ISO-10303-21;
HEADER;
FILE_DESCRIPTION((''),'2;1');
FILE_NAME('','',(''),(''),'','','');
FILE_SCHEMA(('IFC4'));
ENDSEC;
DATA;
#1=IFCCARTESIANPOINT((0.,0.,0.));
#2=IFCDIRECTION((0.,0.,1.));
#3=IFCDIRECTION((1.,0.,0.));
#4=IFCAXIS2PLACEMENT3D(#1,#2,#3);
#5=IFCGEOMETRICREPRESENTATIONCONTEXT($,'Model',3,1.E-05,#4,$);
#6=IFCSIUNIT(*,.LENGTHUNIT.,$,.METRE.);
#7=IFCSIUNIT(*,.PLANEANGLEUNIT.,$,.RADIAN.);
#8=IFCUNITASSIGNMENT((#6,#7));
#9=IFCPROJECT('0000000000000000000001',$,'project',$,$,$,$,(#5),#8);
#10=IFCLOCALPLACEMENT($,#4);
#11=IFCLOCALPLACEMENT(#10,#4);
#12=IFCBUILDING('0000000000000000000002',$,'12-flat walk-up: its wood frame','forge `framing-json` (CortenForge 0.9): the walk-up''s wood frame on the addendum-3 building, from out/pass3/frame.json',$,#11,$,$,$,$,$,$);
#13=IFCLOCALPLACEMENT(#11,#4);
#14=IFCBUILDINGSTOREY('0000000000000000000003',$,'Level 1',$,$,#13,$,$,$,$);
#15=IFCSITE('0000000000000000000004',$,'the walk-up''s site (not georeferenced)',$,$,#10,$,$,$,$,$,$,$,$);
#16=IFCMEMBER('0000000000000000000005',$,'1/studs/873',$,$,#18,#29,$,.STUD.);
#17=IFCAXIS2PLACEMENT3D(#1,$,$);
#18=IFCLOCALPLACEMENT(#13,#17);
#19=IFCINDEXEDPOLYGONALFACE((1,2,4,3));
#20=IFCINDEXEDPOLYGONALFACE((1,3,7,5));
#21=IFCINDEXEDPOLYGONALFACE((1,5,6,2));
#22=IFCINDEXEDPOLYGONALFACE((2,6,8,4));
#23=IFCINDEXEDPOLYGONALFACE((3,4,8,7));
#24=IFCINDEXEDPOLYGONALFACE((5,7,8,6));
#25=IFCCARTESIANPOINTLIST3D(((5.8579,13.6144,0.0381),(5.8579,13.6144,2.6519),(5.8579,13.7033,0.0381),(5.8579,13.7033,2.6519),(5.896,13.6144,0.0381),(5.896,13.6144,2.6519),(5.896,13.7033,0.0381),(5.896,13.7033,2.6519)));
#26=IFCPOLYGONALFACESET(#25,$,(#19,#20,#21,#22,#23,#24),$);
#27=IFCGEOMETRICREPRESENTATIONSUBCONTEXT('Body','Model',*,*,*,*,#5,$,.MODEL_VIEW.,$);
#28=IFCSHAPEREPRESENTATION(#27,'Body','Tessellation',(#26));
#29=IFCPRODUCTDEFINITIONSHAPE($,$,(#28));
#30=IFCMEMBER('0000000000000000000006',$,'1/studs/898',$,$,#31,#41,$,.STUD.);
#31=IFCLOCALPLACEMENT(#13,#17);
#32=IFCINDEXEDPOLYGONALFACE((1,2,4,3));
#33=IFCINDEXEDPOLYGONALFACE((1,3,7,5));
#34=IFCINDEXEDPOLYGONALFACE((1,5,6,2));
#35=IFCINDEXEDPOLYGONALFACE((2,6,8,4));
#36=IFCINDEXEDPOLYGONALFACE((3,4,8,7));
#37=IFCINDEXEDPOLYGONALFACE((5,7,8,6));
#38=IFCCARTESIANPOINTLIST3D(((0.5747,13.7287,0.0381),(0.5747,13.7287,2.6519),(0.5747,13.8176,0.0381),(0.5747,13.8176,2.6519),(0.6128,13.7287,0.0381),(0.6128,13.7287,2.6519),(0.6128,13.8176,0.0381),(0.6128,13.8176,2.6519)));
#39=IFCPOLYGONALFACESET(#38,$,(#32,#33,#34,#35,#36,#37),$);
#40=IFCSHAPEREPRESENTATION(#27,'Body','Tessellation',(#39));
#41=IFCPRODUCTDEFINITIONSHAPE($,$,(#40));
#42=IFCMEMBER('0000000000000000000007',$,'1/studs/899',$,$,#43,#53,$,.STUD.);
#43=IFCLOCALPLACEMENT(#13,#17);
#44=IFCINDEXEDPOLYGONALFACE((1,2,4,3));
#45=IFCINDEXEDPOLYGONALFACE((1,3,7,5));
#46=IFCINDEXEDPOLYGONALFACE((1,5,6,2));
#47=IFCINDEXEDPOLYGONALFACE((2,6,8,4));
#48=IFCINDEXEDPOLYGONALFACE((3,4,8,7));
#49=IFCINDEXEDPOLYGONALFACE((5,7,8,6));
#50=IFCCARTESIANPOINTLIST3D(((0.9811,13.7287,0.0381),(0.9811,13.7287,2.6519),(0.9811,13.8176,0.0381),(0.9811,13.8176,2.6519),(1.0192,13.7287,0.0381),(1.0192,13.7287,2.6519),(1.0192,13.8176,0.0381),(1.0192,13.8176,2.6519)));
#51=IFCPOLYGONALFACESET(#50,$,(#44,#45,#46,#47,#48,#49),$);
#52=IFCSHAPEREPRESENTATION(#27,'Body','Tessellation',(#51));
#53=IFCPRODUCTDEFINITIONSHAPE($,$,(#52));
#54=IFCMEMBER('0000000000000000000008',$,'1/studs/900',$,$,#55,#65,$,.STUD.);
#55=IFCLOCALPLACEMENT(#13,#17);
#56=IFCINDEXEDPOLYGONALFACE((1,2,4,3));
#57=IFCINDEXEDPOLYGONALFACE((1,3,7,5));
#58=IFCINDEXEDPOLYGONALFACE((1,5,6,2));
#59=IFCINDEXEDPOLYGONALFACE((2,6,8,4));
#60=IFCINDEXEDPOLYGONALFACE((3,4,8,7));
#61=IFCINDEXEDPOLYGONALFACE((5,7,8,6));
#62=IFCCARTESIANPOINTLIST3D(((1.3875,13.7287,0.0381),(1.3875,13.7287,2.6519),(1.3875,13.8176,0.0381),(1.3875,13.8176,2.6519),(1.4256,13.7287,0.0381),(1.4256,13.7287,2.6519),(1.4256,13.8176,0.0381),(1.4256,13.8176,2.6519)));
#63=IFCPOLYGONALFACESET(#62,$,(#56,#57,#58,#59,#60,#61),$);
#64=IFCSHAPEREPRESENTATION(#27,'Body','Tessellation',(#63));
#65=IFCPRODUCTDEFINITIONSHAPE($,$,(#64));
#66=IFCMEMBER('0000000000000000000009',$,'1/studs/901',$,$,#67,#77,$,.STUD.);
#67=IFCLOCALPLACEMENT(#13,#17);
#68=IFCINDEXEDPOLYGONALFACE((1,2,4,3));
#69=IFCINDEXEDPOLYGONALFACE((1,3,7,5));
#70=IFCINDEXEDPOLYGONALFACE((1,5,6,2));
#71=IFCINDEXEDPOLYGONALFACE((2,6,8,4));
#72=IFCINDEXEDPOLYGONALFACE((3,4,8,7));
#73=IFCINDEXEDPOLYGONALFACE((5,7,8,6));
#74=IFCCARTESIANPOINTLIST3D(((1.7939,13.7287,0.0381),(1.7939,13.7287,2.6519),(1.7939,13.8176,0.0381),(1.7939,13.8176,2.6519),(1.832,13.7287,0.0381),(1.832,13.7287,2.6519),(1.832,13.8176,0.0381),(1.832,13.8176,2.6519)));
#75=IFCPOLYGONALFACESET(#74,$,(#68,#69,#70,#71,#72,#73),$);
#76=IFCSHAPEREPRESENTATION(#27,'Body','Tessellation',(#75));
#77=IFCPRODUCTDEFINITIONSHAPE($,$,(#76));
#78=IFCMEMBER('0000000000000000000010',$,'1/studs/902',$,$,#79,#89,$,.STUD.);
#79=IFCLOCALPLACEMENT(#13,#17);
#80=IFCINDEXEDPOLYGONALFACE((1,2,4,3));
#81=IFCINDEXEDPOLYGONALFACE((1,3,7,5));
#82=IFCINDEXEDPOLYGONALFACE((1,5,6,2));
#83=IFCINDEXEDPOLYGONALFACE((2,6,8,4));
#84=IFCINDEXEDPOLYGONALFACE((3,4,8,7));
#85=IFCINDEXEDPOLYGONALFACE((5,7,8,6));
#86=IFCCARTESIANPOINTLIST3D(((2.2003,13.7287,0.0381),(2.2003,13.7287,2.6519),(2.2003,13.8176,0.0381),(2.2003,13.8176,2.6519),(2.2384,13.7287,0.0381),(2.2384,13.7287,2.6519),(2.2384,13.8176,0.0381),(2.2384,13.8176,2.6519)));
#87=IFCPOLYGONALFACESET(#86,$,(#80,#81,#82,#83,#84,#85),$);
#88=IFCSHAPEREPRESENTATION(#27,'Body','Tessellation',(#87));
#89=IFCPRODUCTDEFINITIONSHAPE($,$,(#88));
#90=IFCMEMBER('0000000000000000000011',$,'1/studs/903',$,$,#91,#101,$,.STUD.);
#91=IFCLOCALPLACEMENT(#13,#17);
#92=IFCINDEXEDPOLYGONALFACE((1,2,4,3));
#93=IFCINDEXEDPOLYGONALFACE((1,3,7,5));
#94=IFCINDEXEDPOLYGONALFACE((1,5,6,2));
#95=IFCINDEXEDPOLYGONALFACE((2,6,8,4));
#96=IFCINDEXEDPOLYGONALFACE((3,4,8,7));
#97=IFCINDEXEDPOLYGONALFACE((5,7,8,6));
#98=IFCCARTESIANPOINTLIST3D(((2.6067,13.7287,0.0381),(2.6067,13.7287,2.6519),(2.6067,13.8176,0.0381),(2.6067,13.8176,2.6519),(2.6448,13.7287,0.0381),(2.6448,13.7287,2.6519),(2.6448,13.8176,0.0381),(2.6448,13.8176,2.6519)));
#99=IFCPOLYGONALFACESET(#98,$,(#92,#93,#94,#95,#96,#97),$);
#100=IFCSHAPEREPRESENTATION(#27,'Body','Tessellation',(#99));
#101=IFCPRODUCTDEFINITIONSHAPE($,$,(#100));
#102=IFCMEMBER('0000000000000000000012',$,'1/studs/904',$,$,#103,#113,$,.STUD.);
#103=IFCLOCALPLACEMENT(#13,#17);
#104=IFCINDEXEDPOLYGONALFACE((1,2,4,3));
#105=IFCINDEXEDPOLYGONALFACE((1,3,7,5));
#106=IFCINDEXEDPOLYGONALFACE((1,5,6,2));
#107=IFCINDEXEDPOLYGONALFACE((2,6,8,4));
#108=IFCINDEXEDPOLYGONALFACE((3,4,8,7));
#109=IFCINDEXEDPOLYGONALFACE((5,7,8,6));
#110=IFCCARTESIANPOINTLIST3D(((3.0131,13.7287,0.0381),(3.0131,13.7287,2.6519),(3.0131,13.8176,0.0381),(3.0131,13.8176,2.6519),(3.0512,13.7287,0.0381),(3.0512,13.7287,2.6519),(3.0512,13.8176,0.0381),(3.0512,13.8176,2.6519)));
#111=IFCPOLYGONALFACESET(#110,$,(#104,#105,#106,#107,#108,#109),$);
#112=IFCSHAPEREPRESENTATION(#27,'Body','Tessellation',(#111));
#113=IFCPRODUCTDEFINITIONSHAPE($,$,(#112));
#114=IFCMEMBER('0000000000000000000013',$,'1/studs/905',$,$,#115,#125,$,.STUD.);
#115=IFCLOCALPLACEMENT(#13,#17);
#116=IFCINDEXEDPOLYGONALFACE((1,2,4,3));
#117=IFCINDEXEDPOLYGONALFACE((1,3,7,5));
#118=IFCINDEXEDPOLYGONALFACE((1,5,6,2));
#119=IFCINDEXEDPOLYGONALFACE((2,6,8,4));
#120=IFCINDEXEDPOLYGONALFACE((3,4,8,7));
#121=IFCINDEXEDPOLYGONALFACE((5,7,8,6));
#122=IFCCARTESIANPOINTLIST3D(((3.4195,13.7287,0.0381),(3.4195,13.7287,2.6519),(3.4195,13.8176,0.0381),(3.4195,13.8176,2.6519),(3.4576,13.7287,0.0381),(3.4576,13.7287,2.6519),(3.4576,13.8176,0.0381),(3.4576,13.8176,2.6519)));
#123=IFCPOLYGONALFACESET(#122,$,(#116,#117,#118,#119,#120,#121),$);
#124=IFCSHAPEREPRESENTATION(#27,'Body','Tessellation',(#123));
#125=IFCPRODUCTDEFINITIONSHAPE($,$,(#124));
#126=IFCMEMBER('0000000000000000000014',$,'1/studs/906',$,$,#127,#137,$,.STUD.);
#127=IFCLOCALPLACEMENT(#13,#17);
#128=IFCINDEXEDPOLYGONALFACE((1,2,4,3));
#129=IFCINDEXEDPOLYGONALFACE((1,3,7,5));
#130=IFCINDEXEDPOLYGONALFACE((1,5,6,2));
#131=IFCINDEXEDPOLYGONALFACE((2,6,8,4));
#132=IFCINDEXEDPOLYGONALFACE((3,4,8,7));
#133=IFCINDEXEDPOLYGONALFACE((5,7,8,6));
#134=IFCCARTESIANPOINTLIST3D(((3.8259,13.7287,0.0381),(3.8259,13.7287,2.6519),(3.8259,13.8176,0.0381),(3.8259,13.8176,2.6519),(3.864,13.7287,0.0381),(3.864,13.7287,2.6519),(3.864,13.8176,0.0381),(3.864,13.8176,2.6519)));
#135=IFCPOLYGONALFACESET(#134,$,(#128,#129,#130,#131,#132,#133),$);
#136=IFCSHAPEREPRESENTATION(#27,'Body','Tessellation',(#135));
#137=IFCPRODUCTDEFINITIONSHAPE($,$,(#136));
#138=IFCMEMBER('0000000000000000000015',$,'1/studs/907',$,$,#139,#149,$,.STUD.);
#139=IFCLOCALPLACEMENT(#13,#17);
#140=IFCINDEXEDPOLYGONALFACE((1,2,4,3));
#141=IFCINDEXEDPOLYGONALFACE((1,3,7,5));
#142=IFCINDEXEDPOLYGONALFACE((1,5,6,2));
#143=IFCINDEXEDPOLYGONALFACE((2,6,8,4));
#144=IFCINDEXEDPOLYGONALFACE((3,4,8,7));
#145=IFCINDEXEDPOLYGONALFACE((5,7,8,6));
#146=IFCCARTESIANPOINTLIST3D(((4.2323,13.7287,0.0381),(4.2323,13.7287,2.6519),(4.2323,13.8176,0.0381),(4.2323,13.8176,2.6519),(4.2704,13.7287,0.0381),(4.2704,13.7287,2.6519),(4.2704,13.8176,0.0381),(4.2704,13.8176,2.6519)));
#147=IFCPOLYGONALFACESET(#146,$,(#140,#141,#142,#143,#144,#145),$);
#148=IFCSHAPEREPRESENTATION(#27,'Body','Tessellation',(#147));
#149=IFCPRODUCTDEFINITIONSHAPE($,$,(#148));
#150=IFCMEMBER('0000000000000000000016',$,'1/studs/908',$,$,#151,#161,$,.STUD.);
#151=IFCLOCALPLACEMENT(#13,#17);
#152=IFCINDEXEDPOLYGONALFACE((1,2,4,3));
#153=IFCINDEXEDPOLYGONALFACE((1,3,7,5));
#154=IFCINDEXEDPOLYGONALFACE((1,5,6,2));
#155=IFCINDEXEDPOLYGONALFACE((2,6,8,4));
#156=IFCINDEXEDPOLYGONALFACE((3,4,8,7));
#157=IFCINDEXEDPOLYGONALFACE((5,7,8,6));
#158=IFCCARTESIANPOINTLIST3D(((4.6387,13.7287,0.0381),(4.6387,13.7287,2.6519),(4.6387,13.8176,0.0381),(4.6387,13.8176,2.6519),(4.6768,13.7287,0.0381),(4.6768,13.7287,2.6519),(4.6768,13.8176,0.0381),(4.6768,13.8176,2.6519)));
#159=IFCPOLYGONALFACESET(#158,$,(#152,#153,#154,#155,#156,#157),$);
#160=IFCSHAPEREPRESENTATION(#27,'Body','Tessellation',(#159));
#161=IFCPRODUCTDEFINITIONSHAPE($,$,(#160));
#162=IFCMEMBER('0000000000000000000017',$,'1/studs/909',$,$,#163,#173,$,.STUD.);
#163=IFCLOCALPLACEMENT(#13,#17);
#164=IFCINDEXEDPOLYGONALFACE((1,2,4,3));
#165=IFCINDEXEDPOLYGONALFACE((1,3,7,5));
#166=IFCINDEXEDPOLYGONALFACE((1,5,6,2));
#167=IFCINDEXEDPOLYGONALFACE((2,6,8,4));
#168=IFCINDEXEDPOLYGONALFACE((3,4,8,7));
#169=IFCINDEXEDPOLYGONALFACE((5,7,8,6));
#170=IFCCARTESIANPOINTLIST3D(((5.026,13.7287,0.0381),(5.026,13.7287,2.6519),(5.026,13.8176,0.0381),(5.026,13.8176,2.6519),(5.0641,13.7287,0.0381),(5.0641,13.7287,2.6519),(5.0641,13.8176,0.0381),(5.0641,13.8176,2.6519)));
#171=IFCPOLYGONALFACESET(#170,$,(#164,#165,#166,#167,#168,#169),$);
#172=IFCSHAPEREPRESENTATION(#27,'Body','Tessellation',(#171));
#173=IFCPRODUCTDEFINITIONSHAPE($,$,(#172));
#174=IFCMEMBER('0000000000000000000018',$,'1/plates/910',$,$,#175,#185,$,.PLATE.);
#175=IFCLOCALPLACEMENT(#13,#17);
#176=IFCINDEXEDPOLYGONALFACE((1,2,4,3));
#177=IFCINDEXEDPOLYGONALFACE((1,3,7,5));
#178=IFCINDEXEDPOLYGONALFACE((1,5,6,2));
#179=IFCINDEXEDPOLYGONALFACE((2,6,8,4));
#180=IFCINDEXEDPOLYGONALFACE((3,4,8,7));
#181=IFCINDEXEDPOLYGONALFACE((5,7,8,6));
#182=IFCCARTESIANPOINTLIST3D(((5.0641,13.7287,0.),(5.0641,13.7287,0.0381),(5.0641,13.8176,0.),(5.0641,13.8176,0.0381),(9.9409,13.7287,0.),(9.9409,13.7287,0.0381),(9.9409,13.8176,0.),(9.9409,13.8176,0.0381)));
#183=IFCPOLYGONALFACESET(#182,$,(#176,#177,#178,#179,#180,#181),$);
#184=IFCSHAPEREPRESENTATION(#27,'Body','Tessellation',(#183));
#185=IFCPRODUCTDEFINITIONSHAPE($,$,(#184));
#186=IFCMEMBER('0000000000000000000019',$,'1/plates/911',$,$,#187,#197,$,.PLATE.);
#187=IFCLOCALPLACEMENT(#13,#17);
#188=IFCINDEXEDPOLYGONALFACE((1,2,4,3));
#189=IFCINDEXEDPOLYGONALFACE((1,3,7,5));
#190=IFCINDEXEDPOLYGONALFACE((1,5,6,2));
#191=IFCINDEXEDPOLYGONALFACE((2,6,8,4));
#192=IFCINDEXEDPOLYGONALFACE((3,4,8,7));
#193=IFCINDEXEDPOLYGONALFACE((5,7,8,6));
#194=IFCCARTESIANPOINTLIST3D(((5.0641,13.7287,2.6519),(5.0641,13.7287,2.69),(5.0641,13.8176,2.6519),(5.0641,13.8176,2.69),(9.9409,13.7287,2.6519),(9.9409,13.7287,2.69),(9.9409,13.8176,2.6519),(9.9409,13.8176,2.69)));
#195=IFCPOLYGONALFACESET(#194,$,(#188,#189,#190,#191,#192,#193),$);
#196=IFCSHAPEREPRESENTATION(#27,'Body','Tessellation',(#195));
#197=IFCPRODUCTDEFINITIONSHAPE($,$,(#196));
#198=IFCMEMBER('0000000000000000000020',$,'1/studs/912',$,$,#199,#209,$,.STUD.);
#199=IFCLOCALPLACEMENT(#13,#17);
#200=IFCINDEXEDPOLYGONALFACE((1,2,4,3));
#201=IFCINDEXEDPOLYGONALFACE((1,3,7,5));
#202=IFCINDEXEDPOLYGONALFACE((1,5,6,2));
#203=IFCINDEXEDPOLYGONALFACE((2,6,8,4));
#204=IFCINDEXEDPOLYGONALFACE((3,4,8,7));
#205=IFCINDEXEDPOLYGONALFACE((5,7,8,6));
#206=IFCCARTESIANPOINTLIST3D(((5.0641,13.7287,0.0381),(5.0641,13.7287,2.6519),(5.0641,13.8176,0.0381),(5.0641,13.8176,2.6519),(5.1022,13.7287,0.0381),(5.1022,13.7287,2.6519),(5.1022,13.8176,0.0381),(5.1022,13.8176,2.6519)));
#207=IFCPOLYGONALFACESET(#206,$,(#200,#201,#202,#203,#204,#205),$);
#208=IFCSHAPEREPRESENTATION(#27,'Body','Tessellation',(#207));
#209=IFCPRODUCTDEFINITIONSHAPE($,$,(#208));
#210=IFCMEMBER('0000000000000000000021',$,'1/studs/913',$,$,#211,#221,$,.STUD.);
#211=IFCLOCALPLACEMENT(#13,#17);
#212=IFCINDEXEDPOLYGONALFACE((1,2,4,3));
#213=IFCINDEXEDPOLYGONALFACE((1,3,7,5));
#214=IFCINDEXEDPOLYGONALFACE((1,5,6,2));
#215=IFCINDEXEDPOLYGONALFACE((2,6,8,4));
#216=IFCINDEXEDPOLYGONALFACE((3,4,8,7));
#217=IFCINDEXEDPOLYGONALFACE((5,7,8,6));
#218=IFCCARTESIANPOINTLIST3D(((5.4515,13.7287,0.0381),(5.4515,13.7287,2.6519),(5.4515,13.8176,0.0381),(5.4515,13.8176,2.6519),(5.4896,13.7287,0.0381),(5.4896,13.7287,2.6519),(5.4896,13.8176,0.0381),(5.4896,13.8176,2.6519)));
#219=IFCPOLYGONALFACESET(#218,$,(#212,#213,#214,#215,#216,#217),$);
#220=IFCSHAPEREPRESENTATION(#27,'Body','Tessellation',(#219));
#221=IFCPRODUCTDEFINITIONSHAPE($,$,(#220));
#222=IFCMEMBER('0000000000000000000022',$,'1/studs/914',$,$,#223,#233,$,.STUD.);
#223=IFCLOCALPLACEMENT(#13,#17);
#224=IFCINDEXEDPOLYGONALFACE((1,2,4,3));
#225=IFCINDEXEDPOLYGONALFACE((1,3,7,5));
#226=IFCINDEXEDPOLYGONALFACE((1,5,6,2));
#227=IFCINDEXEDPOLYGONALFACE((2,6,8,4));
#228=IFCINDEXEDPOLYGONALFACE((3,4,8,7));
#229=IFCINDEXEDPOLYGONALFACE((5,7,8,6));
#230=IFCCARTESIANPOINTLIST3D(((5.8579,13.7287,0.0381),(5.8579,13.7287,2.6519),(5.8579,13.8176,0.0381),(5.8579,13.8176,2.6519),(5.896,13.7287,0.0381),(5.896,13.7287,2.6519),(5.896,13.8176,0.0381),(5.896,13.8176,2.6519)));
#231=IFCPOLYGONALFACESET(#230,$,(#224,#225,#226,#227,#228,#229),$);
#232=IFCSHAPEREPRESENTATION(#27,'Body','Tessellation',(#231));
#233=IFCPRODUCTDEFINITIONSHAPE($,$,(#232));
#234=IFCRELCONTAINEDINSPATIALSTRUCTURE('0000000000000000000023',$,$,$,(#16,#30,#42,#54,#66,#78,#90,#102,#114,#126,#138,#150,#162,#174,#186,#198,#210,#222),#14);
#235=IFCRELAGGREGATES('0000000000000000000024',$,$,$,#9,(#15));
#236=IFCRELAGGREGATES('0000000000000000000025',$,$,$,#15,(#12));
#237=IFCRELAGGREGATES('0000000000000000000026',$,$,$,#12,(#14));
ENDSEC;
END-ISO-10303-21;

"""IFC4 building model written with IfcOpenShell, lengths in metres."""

from ifc_helpers import new_model, si_unit, frame, frame_2d, origin, origin_with_axes, place, context, subcontext, project, spatial, rectangle, extrude, element, save


model = new_model("IFC4")

# Units and contexts
model_context = context("Model", 3, precision=1e-05, world=origin_with_axes())
body_context = subcontext(model_context, "Body", "Model", "MODEL_VIEW")
ifc_project = project(units=[si_unit("LENGTHUNIT", "METRE"), si_unit("PLANEANGLEUNIT", "RADIAN")], contexts=[model_context])

# Site, building, storey
site_placement = place(None, origin_with_axes())
site = spatial("IfcSite", under=ifc_project, at=site_placement, Name="the walk-up's site (not georeferenced)")
building_placement = place(site_placement, origin_with_axes())
building = spatial("IfcBuilding", under=site, at=building_placement, Name="12-flat walk-up: its wood frame", Description="forge `framing-json` (CortenForge 0.9): the walk-up's wood frame on the addendum-3 building, from out/pass3/frame.json")
storey_placement = place(building_placement, origin_with_axes())
storey = spatial("IfcBuildingStorey", under=building, at=storey_placement, Name="Level 1")

# Members
for number, where, z_axis, x_axis, name in (
    (1, (5.8579, 13.6144, 0.0381), (0.0, 0.0, 1.0), (1.0, 0.0, 0.0), "1/studs/873"),
):
    element("IfcMember", number, at=place(storey_placement, frame(where, z_axis=z_axis, x_axis=x_axis)), inside=storey, Name=name, PredefinedType="STUD", context=body_context, shape_type="SweptSolid", body=[
        extrude(rectangle(XDim=0.0381, YDim=0.0889, at=frame_2d((0.0191, 0.0445))), origin(), (0.0, 0.0, 1.0), 2.6138),
    ])
for number, where, z_axis, x_axis, name in (
    (2, (0.5747, 13.7287, 0.0381), (0.0, 0.0, 1.0), (1.0, 0.0, 0.0), "1/studs/898"),
    (3, (0.9811, 13.7287, 0.0381), (0.0, 0.0, 1.0), (1.0, 0.0, 0.0), "1/studs/899"),
):
    element("IfcMember", number, at=place(storey_placement, frame(where, z_axis=z_axis, x_axis=x_axis)), inside=storey, Name=name, PredefinedType="STUD", context=body_context, shape_type="SweptSolid", body=[
        extrude(rectangle(XDim=0.0381, YDim=0.0889, at=frame_2d((0.019, 0.0445))), origin(), (0.0, 0.0, 1.0), 2.6138),
    ])
member_1_placement = place(storey_placement, frame((1.3875, 13.7287, 0.0381), z_axis=(0.0, 0.0, 1.0), x_axis=(1.0, 0.0, 0.0)))
element("IfcMember", 4, at=member_1_placement, inside=storey, Name="1/studs/900", PredefinedType="STUD", context=body_context, shape_type="SweptSolid", body=[
    extrude(rectangle(XDim=0.0381, YDim=0.0889, at=frame_2d((0.0191, 0.0445))), origin(), (0.0, 0.0, 1.0), 2.6138),
])
member_2_placement = place(storey_placement, frame((1.7939, 13.7287, 0.0381), z_axis=(0.0, 0.0, 1.0), x_axis=(1.0, 0.0, 0.0)))
element("IfcMember", 5, at=member_2_placement, inside=storey, Name="1/studs/901", PredefinedType="STUD", context=body_context, shape_type="SweptSolid", body=[
    extrude(rectangle(XDim=0.0381, YDim=0.0889, at=frame_2d((0.019, 0.0445))), origin(), (0.0, 0.0, 1.0), 2.6138),
])
for number, where, z_axis, x_axis, name in (
    (6, (2.2003, 13.7287, 0.0381), (0.0, 0.0, 1.0), (1.0, 0.0, 0.0), "1/studs/902"),
    (7, (2.6067, 13.7287, 0.0381), (0.0, 0.0, 1.0), (1.0, 0.0, 0.0), "1/studs/903"),
    (8, (3.0131, 13.7287, 0.0381), (0.0, 0.0, 1.0), (1.0, 0.0, 0.0), "1/studs/904"),
    (9, (3.4195, 13.7287, 0.0381), (0.0, 0.0, 1.0), (1.0, 0.0, 0.0), "1/studs/905"),
    (10, (3.8259, 13.7287, 0.0381), (0.0, 0.0, 1.0), (1.0, 0.0, 0.0), "1/studs/906"),
    (11, (4.2323, 13.7287, 0.0381), (0.0, 0.0, 1.0), (1.0, 0.0, 0.0), "1/studs/907"),
    (12, (4.6387, 13.7287, 0.0381), (0.0, 0.0, 1.0), (1.0, 0.0, 0.0), "1/studs/908"),
    (13, (5.026, 13.7287, 0.0381), (0.0, 0.0, 1.0), (1.0, 0.0, 0.0), "1/studs/909"),
):
    element("IfcMember", number, at=place(storey_placement, frame(where, z_axis=z_axis, x_axis=x_axis)), inside=storey, Name=name, PredefinedType="STUD", context=body_context, shape_type="SweptSolid", body=[
        extrude(rectangle(XDim=0.0381, YDim=0.0889, at=frame_2d((0.0191, 0.0445))), origin(), (0.0, 0.0, 1.0), 2.6138),
    ])
member_3_placement = place(storey_placement, frame((5.0641, 13.7287, 0.0), z_axis=(0.0, 0.0, 1.0), x_axis=(1.0, 0.0, 0.0)))
element("IfcMember", 14, at=member_3_placement, inside=storey, Name="1/plates/910", PredefinedType="PLATE", context=body_context, shape_type="SweptSolid", body=[
    extrude(rectangle(XDim=4.8768, YDim=0.0889, at=frame_2d((2.4384, 0.0445))), origin(), (0.0, 0.0, 1.0), 0.0381),
])
member_4_placement = place(storey_placement, frame((5.0641, 13.7287, 2.6519), z_axis=(0.0, 0.0, 1.0), x_axis=(1.0, 0.0, 0.0)))
element("IfcMember", 15, at=member_4_placement, inside=storey, Name="1/plates/911", PredefinedType="PLATE", context=body_context, shape_type="SweptSolid", body=[
    extrude(rectangle(XDim=4.8768, YDim=0.0889, at=frame_2d((2.4384, 0.0445))), origin(), (0.0, 0.0, 1.0), 0.0381),
])
for number, where, z_axis, x_axis, name in (
    (16, (5.0641, 13.7287, 0.0381), (0.0, 0.0, 1.0), (1.0, 0.0, 0.0), "1/studs/912"),
    (17, (5.4515, 13.7287, 0.0381), (0.0, 0.0, 1.0), (1.0, 0.0, 0.0), "1/studs/913"),
    (18, (5.8579, 13.7287, 0.0381), (0.0, 0.0, 1.0), (1.0, 0.0, 0.0), "1/studs/914"),
):
    element("IfcMember", number, at=place(storey_placement, frame(where, z_axis=z_axis, x_axis=x_axis)), inside=storey, Name=name, PredefinedType="STUD", context=body_context, shape_type="SweptSolid", body=[
        extrude(rectangle(XDim=0.0381, YDim=0.0889, at=frame_2d((0.0191, 0.0445))), origin(), (0.0, 0.0, 1.0), 2.6138),
    ])

save(model, "model.ifc")
